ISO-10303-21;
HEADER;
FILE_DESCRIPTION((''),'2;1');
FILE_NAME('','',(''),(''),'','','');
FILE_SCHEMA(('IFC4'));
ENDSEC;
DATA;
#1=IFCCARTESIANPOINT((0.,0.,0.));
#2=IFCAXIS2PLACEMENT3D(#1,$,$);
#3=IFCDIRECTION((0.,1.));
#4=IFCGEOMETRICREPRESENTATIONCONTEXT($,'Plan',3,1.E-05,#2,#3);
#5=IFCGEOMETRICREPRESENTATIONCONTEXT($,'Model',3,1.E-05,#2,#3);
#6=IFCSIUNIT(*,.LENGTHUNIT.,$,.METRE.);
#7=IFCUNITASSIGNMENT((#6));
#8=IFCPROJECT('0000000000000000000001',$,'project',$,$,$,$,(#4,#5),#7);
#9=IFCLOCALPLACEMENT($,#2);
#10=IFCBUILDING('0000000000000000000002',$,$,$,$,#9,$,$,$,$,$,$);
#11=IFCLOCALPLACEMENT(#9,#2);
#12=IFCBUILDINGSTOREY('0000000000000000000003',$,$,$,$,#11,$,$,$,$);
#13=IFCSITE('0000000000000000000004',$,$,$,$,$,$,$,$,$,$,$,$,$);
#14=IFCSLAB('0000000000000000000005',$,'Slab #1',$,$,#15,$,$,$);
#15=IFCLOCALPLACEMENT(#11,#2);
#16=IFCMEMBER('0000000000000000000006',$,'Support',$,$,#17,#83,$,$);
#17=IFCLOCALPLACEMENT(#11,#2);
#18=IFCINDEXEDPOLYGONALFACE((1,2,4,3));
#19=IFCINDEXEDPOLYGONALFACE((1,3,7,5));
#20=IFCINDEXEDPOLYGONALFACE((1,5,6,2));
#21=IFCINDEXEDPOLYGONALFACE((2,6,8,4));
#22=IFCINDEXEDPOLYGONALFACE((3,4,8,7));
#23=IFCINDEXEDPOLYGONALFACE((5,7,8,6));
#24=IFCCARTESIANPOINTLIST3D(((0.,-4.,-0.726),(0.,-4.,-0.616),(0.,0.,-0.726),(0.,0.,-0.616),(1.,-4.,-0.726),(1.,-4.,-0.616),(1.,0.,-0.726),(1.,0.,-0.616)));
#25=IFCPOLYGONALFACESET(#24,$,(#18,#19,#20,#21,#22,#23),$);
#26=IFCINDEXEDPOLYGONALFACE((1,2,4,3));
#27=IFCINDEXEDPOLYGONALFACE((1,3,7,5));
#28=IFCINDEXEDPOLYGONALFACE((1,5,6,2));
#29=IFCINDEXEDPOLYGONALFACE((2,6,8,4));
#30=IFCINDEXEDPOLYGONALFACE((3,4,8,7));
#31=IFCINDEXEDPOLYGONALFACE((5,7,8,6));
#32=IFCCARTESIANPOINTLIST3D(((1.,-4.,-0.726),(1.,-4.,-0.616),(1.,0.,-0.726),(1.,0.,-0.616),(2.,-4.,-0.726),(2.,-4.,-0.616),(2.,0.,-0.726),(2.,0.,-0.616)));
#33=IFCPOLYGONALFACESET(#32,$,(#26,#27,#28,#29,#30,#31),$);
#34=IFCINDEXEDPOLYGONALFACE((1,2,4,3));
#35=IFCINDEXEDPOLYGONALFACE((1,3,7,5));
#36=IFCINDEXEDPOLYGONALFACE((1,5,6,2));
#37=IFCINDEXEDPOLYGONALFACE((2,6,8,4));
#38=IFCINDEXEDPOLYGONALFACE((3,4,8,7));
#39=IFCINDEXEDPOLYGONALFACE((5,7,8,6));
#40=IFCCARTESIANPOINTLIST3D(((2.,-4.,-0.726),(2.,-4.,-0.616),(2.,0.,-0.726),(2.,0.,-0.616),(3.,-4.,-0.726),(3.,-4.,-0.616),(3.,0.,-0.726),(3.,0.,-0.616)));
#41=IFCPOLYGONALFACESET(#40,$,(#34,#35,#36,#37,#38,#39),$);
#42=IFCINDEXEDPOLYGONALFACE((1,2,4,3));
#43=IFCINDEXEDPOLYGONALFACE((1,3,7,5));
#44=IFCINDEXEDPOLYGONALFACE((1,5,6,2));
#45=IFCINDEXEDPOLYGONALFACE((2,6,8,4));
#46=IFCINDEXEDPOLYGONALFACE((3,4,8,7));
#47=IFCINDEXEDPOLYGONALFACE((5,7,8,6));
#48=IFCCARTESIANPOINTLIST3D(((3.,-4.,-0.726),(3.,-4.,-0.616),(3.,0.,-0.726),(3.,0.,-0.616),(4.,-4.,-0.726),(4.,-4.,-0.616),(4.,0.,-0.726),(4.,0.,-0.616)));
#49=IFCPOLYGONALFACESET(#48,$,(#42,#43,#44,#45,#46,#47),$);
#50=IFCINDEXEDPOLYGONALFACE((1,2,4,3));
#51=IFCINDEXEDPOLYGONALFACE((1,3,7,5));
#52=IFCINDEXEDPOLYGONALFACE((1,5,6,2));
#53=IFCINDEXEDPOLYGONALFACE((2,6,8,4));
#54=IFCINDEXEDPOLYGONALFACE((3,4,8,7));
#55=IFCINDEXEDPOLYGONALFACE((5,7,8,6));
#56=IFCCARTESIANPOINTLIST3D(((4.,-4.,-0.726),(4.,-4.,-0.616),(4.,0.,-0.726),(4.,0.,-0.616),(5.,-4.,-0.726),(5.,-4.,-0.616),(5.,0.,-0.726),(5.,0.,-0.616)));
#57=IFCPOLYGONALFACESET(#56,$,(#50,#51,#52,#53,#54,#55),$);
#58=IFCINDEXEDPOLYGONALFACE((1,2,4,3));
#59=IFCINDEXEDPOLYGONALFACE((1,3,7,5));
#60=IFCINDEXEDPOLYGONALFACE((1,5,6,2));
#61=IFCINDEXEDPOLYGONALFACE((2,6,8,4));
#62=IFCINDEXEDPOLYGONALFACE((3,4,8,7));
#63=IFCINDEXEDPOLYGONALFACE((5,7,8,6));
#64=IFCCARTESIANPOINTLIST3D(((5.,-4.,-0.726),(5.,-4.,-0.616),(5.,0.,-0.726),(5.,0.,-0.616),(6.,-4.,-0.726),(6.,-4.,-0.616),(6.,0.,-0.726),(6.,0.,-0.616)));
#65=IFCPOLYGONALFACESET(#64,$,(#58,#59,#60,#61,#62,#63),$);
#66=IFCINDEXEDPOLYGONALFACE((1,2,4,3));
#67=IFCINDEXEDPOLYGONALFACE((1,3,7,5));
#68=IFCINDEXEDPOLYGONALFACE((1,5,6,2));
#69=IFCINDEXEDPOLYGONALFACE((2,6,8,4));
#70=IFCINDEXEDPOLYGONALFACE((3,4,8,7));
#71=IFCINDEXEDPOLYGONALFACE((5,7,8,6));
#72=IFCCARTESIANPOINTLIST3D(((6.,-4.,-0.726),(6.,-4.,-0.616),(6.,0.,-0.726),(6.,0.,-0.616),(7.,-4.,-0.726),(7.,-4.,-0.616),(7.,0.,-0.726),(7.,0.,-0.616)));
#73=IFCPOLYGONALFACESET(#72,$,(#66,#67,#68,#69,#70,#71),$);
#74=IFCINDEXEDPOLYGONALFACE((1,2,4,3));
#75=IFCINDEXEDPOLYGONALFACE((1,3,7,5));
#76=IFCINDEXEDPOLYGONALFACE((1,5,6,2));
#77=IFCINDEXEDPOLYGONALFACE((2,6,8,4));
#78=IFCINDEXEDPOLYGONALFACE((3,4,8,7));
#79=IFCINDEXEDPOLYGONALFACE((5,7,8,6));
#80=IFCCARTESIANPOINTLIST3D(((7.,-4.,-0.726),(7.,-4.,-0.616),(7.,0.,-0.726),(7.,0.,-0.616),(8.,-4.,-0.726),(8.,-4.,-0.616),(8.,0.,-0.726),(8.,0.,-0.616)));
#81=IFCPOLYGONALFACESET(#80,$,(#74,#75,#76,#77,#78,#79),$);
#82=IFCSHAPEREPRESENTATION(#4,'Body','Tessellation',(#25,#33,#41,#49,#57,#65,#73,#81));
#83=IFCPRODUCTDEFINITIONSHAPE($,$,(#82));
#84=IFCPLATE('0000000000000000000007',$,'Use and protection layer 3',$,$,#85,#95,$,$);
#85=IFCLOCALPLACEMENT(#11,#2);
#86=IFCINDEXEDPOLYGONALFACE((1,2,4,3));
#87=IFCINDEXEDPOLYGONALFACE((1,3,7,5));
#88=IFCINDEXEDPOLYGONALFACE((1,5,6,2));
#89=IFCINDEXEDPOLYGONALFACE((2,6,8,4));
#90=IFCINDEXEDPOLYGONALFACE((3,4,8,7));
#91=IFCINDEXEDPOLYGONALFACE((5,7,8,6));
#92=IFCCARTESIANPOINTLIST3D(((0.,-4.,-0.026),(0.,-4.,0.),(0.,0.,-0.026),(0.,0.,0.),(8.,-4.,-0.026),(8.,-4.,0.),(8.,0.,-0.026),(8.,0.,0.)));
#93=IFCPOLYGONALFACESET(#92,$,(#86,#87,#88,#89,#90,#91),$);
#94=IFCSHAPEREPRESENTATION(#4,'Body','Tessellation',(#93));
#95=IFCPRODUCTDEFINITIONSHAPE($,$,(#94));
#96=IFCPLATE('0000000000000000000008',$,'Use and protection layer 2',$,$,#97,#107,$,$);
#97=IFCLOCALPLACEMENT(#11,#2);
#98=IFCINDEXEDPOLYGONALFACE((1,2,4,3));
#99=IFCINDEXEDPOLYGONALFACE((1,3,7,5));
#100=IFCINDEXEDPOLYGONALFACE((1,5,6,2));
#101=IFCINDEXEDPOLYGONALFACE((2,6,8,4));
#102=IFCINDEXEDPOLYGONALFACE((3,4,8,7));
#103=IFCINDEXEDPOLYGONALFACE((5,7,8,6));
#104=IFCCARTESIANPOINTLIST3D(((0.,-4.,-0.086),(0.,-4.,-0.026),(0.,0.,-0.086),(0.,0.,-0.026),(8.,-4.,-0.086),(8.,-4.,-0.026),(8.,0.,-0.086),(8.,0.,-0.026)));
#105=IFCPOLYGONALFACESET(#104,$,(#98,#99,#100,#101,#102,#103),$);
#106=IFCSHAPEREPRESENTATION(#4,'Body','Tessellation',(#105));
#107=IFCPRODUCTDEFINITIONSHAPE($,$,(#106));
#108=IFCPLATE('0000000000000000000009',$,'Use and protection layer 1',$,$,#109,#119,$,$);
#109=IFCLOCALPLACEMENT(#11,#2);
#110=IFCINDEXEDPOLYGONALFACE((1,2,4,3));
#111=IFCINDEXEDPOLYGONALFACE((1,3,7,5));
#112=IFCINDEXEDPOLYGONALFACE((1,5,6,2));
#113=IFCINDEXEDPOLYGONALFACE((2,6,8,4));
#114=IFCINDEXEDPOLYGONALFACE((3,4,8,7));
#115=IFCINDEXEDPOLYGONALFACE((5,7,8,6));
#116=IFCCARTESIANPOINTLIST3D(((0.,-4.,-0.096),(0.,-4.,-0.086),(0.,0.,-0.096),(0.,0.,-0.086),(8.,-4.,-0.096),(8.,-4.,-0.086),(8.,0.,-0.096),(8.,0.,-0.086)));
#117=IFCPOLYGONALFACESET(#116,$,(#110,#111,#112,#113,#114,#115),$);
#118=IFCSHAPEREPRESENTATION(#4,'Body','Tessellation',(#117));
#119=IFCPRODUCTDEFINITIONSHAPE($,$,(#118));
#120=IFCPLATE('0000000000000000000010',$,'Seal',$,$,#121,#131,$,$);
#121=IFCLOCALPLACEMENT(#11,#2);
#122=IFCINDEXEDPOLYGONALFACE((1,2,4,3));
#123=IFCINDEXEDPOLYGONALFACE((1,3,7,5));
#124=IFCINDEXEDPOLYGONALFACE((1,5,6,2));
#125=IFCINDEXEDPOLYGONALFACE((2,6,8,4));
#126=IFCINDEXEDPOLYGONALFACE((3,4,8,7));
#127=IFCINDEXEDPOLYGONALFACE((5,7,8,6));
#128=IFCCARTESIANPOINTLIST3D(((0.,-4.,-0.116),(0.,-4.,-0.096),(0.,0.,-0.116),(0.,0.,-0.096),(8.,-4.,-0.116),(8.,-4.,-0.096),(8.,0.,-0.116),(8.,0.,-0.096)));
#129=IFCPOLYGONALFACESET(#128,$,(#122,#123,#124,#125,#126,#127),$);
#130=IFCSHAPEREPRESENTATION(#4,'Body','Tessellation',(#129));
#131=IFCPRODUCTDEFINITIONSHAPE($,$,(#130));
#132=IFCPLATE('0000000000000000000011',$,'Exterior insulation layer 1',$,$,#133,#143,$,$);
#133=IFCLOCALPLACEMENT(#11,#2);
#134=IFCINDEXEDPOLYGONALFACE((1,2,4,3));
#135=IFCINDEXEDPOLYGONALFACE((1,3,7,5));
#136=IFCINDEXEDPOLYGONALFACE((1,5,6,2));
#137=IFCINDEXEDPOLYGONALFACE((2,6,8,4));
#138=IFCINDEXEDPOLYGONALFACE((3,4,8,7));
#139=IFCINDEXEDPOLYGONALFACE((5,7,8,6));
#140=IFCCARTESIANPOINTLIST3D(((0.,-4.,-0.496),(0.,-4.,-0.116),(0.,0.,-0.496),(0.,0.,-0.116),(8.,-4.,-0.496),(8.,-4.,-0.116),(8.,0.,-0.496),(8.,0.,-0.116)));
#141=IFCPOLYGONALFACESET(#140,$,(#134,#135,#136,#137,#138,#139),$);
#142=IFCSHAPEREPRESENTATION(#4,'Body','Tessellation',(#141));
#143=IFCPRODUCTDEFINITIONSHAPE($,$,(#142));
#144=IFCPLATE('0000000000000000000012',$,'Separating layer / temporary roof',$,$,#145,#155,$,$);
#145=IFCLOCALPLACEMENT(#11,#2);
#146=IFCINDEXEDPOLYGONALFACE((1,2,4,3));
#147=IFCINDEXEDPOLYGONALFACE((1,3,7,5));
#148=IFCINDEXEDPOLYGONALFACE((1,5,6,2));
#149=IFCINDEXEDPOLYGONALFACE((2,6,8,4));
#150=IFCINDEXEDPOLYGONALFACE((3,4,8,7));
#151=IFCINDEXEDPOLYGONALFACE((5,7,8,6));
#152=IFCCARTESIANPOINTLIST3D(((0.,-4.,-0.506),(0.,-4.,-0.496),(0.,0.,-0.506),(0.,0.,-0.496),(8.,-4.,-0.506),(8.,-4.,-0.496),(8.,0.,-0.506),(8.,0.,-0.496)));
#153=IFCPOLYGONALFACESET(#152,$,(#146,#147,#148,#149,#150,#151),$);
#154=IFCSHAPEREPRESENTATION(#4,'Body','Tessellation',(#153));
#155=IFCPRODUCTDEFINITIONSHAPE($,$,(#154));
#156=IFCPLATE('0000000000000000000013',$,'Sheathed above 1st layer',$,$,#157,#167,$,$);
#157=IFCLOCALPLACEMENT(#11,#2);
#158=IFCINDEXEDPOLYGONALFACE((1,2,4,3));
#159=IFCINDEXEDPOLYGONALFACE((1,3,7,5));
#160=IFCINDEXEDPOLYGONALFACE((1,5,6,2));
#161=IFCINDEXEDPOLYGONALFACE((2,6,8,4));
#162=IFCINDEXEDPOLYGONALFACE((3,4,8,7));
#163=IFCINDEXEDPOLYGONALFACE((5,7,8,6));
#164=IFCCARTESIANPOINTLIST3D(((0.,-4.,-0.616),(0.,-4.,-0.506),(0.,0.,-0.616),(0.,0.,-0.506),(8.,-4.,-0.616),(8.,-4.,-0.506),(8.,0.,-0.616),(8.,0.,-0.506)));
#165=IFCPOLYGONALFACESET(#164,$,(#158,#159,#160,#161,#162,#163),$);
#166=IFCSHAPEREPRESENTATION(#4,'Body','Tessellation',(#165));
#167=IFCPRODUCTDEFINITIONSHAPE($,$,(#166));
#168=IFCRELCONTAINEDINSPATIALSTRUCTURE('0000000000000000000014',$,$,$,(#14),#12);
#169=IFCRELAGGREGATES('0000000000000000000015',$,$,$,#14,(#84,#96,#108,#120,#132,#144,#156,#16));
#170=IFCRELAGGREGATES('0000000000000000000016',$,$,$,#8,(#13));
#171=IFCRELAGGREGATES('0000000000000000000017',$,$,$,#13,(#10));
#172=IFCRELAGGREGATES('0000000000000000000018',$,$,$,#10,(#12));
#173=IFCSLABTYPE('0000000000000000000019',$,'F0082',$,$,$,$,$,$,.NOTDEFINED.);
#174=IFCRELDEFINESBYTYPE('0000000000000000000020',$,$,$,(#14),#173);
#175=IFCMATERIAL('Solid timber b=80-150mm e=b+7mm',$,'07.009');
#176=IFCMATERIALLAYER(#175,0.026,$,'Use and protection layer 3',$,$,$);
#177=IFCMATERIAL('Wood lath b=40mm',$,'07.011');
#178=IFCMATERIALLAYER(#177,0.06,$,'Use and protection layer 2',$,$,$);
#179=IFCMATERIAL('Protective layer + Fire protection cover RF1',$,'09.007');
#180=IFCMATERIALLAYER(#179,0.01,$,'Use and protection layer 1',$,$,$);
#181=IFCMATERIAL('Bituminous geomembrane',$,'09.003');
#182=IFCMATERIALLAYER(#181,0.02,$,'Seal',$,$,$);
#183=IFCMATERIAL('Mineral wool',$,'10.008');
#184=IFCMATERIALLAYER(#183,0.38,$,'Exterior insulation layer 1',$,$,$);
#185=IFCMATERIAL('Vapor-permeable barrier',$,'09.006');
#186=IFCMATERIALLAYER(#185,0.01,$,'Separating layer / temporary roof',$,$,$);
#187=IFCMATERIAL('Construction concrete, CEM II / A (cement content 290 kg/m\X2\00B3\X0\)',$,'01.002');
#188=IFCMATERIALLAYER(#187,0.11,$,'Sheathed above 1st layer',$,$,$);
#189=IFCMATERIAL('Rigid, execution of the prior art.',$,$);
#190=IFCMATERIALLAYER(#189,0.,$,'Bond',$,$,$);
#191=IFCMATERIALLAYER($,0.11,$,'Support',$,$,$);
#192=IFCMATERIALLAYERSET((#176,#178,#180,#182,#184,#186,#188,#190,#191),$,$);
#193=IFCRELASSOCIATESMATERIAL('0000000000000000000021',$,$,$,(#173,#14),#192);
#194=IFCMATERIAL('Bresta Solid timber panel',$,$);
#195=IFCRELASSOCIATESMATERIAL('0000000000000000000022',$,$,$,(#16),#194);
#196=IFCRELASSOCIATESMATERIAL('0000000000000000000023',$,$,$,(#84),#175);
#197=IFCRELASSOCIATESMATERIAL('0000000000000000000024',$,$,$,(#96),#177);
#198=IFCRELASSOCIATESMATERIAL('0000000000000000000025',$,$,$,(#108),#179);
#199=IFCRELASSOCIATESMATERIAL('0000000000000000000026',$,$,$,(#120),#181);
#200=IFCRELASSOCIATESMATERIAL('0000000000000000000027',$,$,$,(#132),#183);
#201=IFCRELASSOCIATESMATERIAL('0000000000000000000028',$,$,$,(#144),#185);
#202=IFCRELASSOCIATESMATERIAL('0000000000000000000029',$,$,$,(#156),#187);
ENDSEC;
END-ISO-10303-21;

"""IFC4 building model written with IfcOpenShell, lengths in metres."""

from ifc_helpers import new_model, si_unit, direction, frame, frame_2d, origin, origin_with_axes, place, context, project, spatial, rectangle, extrude, material, layer, layer_set, type_object, element, aggregate, save


model = new_model("IFC4")

# Units and contexts
plan_context = context("Plan", 3, precision=1e-05, world=origin(), true_north=direction((0.0, 1.0)))
model_context = context("Model", 3, precision=1e-05, world=origin(), true_north=direction((0.0, 1.0)))
ifc_project = project(units=[si_unit("LENGTHUNIT", "METRE")], contexts=[plan_context, model_context])

# Site, building, storey
site = spatial("IfcSite", under=ifc_project)
building_placement = place(None, origin())
building = spatial("IfcBuilding", under=site, at=building_placement)
storey_placement = place(building_placement, origin())
storey = spatial("IfcBuildingStorey", under=building, at=storey_placement)

# Slab, member, plates
ifc_material_1 = material(Name="Solid timber b=80-150mm e=b+7mm", Category="07.009")
ifc_layer_1 = layer(ifc_material_1, 0.026, Name="Use and protection layer 3")
ifc_material_2 = material(Name="Wood lath b=40mm", Category="07.011")
ifc_layer_2 = layer(ifc_material_2, 0.06, Name="Use and protection layer 2")
ifc_material_3 = material(Name="Protective layer + Fire protection cover RF1", Category="09.007")
ifc_layer_3 = layer(ifc_material_3, 0.01, Name="Use and protection layer 1")
ifc_material_4 = material(Name="Bituminous geomembrane", Category="09.003")
ifc_layer_4 = layer(ifc_material_4, 0.02, Name="Seal")
ifc_material_5 = material(Name="Mineral wool", Category="10.008")
ifc_layer_5 = layer(ifc_material_5, 0.38, Name="Exterior insulation layer 1")
ifc_material_6 = material(Name="Vapor-permeable barrier", Category="09.006")
ifc_layer_6 = layer(ifc_material_6, 0.01, Name="Separating layer / temporary roof")
ifc_material_7 = material(Name="Construction concrete, CEM II / A (cement content 290 kg/m³)", Category="01.002")
ifc_layer_7 = layer(ifc_material_7, 0.11, Name="Sheathed above 1st layer")
ifc_material_8 = material(Name="Rigid, execution of the prior art.")
ifc_layer_8 = layer(ifc_material_8, 0.0, Name="Bond")
ifc_layer_9 = layer(None, 0.11, Name="Support")
ifc_layer_set = layer_set([ifc_layer_1, ifc_layer_2, ifc_layer_3, ifc_layer_4, ifc_layer_5, ifc_layer_6, ifc_layer_7, ifc_layer_8, ifc_layer_9])
slab_type = type_object("IfcSlabType", Name="F0082", PredefinedType="NOTDEFINED", material=ifc_layer_set)
slab_placement = place(None, frame((0.0, 0.0, 0.0), z_axis=(0.0, 0.0, -1.0), x_axis=(1.0, 0.0, 0.0)))
slab = element("IfcSlab", 1, at=slab_placement, inside=storey, type_object=slab_type, material=ifc_layer_set, Name="Slab #1")
ifc_material_9 = material(Name="Bresta Solid timber panel")
member_placement = place(slab_placement, origin())
member = element("IfcMember", 2, at=member_placement, material=ifc_material_9, Name="Support", context=plan_context, shape_type="SweptSolid", body=[
    extrude(rectangle(XDim=1.0, YDim=0.11, at=frame_2d((0.5, 0.055), x_axis=(1.0, 0.0))), frame((0.0, 4.0, 0.616), z_axis=(0.0, -1.0, 0.0), x_axis=(1.0, 0.0, 0.0)), (0.0, 0.0, 1.0), 4.0),
    extrude(rectangle(XDim=1.0, YDim=0.11, at=frame_2d((0.5, 0.055), x_axis=(1.0, 0.0))), frame((1.0, 4.0, 0.616), z_axis=(0.0, -1.0, 0.0), x_axis=(1.0, 0.0, 0.0)), (0.0, 0.0, 1.0), 4.0),
    extrude(rectangle(XDim=1.0, YDim=0.11, at=frame_2d((0.5, 0.055), x_axis=(1.0, 0.0))), frame((2.0, 4.0, 0.616), z_axis=(0.0, -1.0, 0.0), x_axis=(1.0, 0.0, 0.0)), (0.0, 0.0, 1.0), 4.0),
    extrude(rectangle(XDim=1.0, YDim=0.11, at=frame_2d((0.5, 0.055), x_axis=(1.0, 0.0))), frame((3.0, 4.0, 0.616), z_axis=(0.0, -1.0, 0.0), x_axis=(1.0, 0.0, 0.0)), (0.0, 0.0, 1.0), 4.0),
    extrude(rectangle(XDim=1.0, YDim=0.11, at=frame_2d((0.5, 0.055), x_axis=(1.0, 0.0))), frame((4.0, 4.0, 0.616), z_axis=(0.0, -1.0, 0.0), x_axis=(1.0, 0.0, 0.0)), (0.0, 0.0, 1.0), 4.0),
    extrude(rectangle(XDim=1.0, YDim=0.11, at=frame_2d((0.5, 0.055), x_axis=(1.0, 0.0))), frame((5.0, 4.0, 0.616), z_axis=(0.0, -1.0, 0.0), x_axis=(1.0, 0.0, 0.0)), (0.0, 0.0, 1.0), 4.0),
    extrude(rectangle(XDim=1.0, YDim=0.11, at=frame_2d((0.5, 0.055), x_axis=(1.0, 0.0))), frame((6.0, 4.0, 0.616), z_axis=(0.0, -1.0, 0.0), x_axis=(1.0, 0.0, 0.0)), (0.0, 0.0, 1.0), 4.0),
    extrude(rectangle(XDim=1.0, YDim=0.11, at=frame_2d((0.5, 0.055), x_axis=(1.0, 0.0))), frame((7.0, 4.0, 0.616), z_axis=(0.0, -1.0, 0.0), x_axis=(1.0, 0.0, 0.0)), (0.0, 0.0, 1.0), 4.0),
])
plate_1_placement = place(slab_placement, origin())
plate_1 = element("IfcPlate", 3, at=plate_1_placement, material=ifc_material_1, Name="Use and protection layer 3", context=plan_context, shape_type="SweptSolid", body=[
    extrude(rectangle(XDim=8.0, YDim=4.0, at=frame_2d((4.0, 2.0), x_axis=(1.0, 0.0))), origin_with_axes(), (0.0, 0.0, 1.0), 0.026),
])
plate_2_placement = place(slab_placement, origin())
plate_2 = element("IfcPlate", 4, at=plate_2_placement, material=ifc_material_2, Name="Use and protection layer 2", context=plan_context, shape_type="SweptSolid", body=[
    extrude(rectangle(XDim=8.0, YDim=4.0, at=frame_2d((4.0, 2.0), x_axis=(1.0, 0.0))), frame((0.0, 0.0, 0.026), z_axis=(0.0, 0.0, 1.0), x_axis=(1.0, 0.0, 0.0)), (0.0, 0.0, 1.0), 0.06),
])
plate_3_placement = place(slab_placement, origin())
plate_3 = element("IfcPlate", 5, at=plate_3_placement, material=ifc_material_3, Name="Use and protection layer 1", context=plan_context, shape_type="SweptSolid", body=[
    extrude(rectangle(XDim=8.0, YDim=4.0, at=frame_2d((4.0, 2.0), x_axis=(1.0, 0.0))), frame((0.0, 0.0, 0.086), z_axis=(0.0, 0.0, 1.0), x_axis=(1.0, 0.0, 0.0)), (0.0, 0.0, 1.0), 0.01),
])
plate_4_placement = place(slab_placement, origin())
plate_4 = element("IfcPlate", 6, at=plate_4_placement, material=ifc_material_4, Name="Seal", context=plan_context, shape_type="SweptSolid", body=[
    extrude(rectangle(XDim=8.0, YDim=4.0, at=frame_2d((4.0, 2.0), x_axis=(1.0, 0.0))), frame((0.0, 0.0, 0.096), z_axis=(0.0, 0.0, 1.0), x_axis=(1.0, 0.0, 0.0)), (0.0, 0.0, 1.0), 0.02),
])
plate_5_placement = place(slab_placement, origin())
plate_5 = element("IfcPlate", 7, at=plate_5_placement, material=ifc_material_5, Name="Exterior insulation layer 1", context=plan_context, shape_type="SweptSolid", body=[
    extrude(rectangle(XDim=8.0, YDim=4.0, at=frame_2d((4.0, 2.0), x_axis=(1.0, 0.0))), frame((0.0, 0.0, 0.116), z_axis=(0.0, 0.0, 1.0), x_axis=(1.0, 0.0, 0.0)), (0.0, 0.0, 1.0), 0.38),
])
plate_6_placement = place(slab_placement, origin())
plate_6 = element("IfcPlate", 8, at=plate_6_placement, material=ifc_material_6, Name="Separating layer / temporary roof", context=plan_context, shape_type="SweptSolid", body=[
    extrude(rectangle(XDim=8.0, YDim=4.0, at=frame_2d((4.0, 2.0), x_axis=(1.0, 0.0))), frame((0.0, 0.0, 0.496), z_axis=(0.0, 0.0, 1.0), x_axis=(1.0, 0.0, 0.0)), (0.0, 0.0, 1.0), 0.01),
])
plate_7_placement = place(slab_placement, origin())
plate_7 = element("IfcPlate", 9, at=plate_7_placement, material=ifc_material_7, Name="Sheathed above 1st layer", context=plan_context, shape_type="SweptSolid", body=[
    extrude(rectangle(XDim=8.0, YDim=4.0, at=frame_2d((4.0, 2.0), x_axis=(1.0, 0.0))), frame((0.0, 0.0, 0.506), z_axis=(0.0, 0.0, 1.0), x_axis=(1.0, 0.0, 0.0)), (0.0, 0.0, 1.0), 0.11),
])
aggregate(slab, [plate_1, plate_2, plate_3, plate_4, plate_5, plate_6, plate_7, member])

save(model, "model.ifc")
